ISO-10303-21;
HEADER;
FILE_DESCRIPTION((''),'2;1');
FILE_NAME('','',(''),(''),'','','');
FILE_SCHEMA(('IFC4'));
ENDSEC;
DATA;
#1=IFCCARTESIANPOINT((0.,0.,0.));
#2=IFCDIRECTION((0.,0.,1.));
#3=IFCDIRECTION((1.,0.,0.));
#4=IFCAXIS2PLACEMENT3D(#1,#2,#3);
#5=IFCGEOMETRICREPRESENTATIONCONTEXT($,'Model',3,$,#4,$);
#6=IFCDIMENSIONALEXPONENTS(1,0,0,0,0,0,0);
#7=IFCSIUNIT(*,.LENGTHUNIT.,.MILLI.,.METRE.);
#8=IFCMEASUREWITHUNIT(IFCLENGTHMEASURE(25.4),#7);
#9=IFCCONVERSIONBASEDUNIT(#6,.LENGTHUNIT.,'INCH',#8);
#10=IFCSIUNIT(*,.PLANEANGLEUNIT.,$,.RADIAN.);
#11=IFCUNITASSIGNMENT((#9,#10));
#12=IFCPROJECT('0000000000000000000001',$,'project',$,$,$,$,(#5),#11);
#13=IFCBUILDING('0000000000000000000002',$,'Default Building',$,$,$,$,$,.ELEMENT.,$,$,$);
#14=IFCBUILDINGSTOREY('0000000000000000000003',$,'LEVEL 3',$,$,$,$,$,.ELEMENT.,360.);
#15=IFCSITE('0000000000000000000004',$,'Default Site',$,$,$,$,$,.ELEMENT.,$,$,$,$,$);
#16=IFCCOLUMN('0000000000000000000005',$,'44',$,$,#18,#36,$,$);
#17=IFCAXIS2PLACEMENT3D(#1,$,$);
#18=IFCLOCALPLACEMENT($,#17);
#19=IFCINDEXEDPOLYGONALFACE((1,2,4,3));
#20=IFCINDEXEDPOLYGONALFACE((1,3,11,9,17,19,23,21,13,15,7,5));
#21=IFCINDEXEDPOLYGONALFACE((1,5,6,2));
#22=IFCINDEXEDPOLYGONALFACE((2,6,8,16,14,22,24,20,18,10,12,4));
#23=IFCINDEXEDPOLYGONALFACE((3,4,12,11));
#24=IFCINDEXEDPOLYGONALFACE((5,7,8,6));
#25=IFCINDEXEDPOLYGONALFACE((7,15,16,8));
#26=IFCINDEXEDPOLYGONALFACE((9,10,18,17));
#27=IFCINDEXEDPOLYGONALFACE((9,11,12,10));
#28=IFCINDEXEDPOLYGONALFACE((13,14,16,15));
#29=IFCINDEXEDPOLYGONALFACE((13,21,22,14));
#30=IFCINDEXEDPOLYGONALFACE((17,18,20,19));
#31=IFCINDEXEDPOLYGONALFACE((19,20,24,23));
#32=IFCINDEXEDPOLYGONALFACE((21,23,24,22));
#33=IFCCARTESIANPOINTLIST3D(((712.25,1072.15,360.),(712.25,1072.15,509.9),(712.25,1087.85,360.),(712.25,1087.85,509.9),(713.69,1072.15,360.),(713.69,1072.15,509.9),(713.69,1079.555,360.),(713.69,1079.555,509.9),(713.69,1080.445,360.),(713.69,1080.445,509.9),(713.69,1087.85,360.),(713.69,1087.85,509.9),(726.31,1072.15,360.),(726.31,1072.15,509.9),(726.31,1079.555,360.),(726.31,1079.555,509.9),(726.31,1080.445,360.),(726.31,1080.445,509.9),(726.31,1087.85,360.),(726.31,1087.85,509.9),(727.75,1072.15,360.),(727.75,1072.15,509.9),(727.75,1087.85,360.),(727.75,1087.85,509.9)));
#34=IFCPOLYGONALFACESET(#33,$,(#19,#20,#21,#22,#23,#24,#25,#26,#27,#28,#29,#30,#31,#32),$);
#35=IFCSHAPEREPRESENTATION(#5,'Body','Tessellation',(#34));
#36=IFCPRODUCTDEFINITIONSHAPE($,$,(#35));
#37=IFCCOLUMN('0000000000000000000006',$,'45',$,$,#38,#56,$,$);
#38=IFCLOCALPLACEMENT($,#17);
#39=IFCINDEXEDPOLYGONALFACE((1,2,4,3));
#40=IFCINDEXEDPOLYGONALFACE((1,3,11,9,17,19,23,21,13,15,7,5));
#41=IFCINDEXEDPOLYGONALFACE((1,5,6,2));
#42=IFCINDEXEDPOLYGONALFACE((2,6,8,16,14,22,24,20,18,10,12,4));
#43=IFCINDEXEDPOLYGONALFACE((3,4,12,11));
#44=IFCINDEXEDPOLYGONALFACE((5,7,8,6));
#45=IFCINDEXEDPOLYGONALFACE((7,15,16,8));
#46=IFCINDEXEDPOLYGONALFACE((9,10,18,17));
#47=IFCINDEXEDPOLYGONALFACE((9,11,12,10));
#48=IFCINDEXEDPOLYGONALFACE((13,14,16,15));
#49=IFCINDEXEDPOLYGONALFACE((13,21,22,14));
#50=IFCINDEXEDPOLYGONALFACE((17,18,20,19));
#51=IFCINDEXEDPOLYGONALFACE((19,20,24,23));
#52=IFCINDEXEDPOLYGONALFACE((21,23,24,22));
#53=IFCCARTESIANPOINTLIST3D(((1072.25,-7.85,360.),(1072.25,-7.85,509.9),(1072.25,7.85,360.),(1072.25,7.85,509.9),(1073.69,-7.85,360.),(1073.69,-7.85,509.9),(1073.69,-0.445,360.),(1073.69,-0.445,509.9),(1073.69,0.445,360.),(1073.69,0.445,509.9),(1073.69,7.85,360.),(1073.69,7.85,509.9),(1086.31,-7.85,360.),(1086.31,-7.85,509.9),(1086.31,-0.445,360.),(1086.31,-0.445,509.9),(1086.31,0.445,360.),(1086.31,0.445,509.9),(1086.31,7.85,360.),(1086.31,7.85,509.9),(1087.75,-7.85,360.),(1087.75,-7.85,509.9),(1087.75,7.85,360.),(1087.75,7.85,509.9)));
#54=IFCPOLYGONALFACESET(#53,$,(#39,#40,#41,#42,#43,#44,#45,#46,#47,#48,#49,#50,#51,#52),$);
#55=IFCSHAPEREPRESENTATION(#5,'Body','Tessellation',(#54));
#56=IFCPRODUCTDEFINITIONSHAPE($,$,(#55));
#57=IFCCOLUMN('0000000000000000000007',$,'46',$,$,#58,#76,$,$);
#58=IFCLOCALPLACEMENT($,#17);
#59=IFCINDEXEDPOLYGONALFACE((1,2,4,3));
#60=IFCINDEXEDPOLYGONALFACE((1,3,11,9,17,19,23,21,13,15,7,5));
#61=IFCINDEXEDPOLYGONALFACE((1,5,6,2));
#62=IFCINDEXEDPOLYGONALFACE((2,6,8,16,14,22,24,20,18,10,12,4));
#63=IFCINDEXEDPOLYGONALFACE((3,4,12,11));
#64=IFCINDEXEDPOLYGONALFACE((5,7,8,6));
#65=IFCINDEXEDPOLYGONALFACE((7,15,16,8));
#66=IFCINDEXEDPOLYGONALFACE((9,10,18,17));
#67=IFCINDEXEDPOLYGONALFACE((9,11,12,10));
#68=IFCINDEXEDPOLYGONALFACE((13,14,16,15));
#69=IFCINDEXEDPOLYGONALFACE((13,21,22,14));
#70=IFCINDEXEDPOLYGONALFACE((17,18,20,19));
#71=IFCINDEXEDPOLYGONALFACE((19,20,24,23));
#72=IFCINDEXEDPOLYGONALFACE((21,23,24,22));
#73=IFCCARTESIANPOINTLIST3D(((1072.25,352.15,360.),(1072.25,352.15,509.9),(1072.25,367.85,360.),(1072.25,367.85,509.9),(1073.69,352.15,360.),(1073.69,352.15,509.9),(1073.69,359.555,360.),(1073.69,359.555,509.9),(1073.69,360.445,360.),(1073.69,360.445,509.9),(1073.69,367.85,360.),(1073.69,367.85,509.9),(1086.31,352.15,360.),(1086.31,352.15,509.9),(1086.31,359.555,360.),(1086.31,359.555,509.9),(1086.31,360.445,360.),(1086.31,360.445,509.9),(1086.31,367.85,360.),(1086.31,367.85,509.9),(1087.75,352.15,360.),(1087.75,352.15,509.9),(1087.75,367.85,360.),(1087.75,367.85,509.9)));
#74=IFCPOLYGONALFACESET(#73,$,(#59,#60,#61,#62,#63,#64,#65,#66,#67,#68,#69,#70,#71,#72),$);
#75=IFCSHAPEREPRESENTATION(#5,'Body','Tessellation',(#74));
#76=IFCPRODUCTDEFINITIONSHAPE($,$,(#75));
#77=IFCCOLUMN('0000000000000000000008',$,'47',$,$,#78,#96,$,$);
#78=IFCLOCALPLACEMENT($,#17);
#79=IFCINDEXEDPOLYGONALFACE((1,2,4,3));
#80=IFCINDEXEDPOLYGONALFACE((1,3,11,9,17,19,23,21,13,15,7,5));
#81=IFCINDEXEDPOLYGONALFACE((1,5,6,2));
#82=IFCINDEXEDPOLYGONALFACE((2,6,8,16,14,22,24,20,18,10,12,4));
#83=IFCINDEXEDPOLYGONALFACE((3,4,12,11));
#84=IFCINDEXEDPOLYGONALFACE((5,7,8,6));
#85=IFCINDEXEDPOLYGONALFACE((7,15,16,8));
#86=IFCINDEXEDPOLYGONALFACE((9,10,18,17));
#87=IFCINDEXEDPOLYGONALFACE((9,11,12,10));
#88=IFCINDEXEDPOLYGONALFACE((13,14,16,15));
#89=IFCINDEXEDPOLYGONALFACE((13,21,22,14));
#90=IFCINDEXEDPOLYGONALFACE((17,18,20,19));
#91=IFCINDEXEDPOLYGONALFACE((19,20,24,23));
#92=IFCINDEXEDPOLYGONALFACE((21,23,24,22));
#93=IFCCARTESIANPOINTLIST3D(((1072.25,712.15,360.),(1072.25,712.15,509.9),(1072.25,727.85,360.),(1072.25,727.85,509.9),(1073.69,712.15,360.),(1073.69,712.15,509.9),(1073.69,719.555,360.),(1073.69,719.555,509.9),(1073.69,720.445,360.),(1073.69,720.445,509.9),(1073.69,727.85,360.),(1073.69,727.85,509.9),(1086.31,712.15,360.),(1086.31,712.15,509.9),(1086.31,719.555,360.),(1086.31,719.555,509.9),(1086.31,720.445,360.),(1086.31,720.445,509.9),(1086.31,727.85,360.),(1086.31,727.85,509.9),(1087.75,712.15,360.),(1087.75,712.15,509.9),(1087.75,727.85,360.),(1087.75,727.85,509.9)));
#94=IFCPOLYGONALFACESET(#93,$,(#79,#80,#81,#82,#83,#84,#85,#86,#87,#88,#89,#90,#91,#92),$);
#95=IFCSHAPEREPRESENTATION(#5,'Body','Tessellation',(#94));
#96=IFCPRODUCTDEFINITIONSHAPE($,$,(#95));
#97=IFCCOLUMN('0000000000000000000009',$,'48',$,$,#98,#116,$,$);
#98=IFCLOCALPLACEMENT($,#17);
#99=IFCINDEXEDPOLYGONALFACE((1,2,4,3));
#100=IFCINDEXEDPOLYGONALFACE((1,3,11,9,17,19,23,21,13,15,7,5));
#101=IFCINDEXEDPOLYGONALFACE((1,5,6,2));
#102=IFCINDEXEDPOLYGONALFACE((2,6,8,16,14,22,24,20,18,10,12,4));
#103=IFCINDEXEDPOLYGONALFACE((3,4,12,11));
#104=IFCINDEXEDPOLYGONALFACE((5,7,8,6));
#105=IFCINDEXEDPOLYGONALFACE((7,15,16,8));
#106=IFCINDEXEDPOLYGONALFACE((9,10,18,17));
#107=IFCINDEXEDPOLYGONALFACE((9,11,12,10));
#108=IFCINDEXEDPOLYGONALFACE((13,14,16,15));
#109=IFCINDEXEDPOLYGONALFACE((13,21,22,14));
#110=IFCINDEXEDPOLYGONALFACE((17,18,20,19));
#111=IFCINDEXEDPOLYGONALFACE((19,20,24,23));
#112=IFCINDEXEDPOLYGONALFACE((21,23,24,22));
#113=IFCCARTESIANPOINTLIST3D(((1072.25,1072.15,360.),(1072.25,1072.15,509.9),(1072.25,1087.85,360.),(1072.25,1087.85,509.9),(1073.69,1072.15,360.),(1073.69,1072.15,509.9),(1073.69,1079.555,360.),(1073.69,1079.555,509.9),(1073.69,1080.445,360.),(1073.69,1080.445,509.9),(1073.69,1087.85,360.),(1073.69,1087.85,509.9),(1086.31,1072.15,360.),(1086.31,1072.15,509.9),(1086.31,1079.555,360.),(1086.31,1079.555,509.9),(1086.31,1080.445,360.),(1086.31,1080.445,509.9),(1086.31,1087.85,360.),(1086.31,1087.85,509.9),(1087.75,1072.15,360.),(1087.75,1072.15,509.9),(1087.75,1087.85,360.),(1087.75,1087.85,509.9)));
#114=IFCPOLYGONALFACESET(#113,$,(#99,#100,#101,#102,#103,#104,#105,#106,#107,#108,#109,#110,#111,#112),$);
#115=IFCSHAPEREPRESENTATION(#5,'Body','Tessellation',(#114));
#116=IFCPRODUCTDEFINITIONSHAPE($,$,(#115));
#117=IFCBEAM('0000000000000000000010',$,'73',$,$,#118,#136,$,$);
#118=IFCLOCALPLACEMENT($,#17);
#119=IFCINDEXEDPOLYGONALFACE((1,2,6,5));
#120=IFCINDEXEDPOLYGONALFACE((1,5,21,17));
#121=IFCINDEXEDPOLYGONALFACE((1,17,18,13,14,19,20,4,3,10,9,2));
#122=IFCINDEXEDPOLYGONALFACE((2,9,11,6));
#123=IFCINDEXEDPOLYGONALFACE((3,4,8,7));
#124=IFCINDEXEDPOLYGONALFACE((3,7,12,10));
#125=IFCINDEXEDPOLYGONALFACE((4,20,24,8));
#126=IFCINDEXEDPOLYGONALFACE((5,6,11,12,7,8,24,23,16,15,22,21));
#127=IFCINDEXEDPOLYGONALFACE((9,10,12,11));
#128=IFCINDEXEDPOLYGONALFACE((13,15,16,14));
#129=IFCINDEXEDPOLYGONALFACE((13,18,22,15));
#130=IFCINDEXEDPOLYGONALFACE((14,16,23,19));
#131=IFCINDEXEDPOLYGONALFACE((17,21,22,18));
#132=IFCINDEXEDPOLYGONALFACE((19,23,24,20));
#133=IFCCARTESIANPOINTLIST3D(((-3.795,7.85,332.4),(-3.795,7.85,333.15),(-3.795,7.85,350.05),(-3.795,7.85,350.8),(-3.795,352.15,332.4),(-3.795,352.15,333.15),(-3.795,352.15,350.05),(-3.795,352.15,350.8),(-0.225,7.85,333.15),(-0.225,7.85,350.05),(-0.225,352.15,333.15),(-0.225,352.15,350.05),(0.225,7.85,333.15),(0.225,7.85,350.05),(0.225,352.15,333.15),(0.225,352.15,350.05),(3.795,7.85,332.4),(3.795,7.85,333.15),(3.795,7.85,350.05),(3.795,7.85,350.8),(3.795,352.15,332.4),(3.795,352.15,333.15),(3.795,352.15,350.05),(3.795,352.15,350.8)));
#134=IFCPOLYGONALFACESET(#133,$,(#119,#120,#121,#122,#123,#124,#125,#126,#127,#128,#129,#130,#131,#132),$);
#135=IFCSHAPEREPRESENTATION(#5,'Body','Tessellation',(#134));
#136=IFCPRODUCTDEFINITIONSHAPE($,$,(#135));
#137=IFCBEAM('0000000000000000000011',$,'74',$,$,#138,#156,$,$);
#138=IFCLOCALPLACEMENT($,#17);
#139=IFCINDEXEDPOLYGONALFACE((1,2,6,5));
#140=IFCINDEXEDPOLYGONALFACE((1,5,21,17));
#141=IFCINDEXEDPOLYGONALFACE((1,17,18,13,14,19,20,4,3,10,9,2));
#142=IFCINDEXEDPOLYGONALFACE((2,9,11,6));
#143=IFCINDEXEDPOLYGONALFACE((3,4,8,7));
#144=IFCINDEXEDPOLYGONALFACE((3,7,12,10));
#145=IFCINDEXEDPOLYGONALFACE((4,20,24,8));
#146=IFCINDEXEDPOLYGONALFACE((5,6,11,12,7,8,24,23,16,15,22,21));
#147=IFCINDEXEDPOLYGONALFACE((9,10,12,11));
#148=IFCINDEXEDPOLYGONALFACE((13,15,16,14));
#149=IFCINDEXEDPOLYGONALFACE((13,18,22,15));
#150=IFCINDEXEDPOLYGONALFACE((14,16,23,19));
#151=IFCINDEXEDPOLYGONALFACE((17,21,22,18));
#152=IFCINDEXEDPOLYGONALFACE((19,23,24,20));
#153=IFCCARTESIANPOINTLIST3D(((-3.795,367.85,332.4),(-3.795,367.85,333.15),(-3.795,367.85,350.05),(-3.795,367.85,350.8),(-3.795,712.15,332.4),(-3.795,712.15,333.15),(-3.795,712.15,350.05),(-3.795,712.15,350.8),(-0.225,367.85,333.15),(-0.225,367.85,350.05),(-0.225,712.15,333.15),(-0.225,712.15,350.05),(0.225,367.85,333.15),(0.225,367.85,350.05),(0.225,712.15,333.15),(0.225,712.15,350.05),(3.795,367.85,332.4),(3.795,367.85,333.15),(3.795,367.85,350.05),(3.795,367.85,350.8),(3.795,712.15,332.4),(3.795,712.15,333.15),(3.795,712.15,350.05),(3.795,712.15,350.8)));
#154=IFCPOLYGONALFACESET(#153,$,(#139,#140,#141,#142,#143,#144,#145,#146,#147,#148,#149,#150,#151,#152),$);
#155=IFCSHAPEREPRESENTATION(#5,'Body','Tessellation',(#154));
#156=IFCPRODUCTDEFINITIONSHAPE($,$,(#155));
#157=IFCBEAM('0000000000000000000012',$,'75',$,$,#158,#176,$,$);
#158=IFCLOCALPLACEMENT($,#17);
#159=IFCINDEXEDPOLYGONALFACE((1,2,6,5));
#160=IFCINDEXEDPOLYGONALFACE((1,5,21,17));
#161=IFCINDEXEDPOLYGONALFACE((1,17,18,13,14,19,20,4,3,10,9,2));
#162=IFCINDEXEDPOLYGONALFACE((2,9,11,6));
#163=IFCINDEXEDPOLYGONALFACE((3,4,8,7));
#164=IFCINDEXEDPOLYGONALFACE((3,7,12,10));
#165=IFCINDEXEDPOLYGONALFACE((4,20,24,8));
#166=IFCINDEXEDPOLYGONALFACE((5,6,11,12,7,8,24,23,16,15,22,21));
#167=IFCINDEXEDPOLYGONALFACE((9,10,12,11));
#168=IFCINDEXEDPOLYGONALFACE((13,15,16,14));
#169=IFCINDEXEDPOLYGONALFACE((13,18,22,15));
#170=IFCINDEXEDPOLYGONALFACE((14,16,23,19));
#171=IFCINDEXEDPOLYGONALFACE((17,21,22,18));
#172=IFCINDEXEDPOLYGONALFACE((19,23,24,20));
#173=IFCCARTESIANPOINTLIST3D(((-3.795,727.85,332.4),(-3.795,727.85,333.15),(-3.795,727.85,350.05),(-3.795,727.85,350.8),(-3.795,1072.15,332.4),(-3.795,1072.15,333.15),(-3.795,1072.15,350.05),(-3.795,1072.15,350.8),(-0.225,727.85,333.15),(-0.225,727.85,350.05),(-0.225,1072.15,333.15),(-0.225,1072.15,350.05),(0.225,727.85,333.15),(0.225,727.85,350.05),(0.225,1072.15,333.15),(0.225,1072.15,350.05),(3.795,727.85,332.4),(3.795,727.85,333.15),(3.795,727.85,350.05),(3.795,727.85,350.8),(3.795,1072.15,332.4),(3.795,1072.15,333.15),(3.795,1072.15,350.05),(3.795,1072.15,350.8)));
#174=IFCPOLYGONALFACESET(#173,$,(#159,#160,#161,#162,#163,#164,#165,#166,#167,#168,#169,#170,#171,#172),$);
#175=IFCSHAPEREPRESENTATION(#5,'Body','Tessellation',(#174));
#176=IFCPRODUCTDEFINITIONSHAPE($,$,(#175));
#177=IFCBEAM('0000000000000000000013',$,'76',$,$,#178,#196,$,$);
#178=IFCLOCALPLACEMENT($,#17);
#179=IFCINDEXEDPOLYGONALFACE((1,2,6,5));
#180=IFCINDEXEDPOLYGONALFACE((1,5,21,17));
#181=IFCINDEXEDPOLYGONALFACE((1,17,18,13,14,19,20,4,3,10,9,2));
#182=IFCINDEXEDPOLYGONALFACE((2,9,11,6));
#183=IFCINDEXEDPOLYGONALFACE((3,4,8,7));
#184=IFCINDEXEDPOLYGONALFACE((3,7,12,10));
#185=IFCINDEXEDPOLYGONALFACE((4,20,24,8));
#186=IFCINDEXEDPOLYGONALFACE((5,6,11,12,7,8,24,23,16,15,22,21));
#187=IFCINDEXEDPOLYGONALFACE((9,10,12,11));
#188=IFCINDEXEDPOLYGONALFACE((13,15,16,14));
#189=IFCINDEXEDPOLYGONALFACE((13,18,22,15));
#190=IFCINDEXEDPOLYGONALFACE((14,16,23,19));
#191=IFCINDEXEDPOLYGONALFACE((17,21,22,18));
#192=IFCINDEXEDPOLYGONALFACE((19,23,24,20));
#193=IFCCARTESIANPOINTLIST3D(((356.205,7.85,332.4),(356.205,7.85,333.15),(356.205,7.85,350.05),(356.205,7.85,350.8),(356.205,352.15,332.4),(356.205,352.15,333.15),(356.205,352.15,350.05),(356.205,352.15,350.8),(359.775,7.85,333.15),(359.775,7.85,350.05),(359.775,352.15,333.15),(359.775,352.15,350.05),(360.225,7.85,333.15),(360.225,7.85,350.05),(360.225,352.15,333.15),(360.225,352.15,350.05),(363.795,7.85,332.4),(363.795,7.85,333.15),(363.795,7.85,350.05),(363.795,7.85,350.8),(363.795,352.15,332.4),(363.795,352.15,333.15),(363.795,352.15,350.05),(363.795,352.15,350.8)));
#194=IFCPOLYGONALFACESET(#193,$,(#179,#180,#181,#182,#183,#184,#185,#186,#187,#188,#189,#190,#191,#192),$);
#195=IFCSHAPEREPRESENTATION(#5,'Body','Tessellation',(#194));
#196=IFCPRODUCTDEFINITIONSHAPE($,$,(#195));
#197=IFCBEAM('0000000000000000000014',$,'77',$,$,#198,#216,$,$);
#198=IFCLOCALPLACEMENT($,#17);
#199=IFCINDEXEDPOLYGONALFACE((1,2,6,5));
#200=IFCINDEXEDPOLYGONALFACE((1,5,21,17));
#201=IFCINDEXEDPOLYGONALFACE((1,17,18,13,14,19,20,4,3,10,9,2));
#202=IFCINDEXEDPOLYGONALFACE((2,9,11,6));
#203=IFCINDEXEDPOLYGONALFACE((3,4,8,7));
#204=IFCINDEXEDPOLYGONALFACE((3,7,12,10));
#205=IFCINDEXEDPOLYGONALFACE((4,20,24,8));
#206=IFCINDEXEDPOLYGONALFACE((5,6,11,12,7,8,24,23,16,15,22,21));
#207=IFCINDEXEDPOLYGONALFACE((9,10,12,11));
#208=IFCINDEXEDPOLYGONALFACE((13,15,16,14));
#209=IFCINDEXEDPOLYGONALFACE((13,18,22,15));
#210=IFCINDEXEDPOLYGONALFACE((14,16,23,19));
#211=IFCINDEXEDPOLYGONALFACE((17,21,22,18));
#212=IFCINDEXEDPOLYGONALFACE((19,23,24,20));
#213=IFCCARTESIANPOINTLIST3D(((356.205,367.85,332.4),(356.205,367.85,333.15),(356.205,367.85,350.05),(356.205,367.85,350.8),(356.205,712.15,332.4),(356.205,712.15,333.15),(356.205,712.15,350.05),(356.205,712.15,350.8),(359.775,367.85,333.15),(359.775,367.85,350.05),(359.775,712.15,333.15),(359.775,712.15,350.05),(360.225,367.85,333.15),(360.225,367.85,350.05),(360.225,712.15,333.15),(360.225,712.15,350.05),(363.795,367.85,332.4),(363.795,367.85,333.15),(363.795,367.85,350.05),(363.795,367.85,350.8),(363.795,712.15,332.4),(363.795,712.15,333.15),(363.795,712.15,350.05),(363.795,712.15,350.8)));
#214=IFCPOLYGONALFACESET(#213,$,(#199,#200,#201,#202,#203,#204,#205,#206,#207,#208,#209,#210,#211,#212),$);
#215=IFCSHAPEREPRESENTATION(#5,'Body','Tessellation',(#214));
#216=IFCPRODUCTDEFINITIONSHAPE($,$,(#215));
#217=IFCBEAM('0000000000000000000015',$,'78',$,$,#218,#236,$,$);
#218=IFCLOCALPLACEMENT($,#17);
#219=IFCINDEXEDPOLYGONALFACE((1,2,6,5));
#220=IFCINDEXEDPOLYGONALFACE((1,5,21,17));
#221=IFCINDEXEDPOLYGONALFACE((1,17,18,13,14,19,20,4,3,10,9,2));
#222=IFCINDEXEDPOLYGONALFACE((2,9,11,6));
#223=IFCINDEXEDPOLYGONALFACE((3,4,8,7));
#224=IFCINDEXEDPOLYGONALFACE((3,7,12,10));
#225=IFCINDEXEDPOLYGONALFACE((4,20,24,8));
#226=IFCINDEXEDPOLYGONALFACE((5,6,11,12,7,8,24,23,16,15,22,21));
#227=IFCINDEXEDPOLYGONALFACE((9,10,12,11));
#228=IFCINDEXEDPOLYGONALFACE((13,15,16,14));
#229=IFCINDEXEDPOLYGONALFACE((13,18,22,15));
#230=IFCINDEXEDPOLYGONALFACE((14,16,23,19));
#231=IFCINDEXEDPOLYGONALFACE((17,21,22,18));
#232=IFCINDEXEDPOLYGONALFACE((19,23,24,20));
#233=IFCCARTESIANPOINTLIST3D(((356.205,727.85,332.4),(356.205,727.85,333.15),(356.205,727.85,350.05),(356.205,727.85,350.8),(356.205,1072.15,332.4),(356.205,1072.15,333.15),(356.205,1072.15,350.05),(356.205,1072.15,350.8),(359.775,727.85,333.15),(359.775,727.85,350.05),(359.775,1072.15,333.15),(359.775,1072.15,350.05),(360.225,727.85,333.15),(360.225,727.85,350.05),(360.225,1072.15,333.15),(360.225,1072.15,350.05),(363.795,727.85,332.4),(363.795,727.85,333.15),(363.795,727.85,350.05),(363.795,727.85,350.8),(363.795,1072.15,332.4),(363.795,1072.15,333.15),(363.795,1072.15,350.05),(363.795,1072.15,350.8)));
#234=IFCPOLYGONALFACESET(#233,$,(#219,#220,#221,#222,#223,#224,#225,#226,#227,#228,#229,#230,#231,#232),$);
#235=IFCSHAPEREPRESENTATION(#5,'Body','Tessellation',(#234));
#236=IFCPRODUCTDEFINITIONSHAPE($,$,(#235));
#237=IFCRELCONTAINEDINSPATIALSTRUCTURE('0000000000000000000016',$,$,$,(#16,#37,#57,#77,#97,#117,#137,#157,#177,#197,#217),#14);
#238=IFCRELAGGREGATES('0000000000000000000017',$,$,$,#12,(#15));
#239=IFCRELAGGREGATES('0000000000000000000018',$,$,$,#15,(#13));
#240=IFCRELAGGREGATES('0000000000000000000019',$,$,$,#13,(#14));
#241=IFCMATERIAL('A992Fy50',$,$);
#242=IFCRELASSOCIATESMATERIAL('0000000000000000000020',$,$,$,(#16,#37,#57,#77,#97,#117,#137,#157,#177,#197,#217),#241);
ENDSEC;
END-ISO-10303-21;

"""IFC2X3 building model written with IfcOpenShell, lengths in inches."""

from ifc_helpers import new_model, entity, si_unit, converted_unit, frame, origin_with_axes, origin_2d_with_axis, place, context, project, spatial, i_section, transform_2d, derived_profile, extrude, material, element, save


model = new_model("IFC2X3")

# Units and contexts
model_context = context("Model", 3, world=origin_with_axes())
ifc_project = project(units=[converted_unit("LENGTHUNIT", "INCH", entity("IfcLengthMeasure", 25.4), si_unit("LENGTHUNIT", "METRE", prefix="MILLI"), dimensions=[1, 0, 0, 0, 0, 0, 0]), si_unit("PLANEANGLEUNIT", "RADIAN")], contexts=[model_context])

# Site, building, storey
site = spatial("IfcSite", under=ifc_project, Name="Default Site", CompositionType="ELEMENT")
building = spatial("IfcBuilding", under=site, Name="Default Building", CompositionType="ELEMENT")
storey = spatial("IfcBuildingStorey", under=building, Name="LEVEL 3", CompositionType="ELEMENT", Elevation=360.0)

# Columns
ifc_material = material(Name="A992Fy50")
for number, where, z_axis, x_axis, name in (
    (1, (720.0, 1080.0, 360.0), (0.0, 0.0, 1.0), (0.0, -1.0, 0.0), "44"),
    (2, (1080.0, 0.0, 360.0), (0.0, 0.0, 1.0), (0.0, -1.0, 0.0), "45"),
    (3, (1080.0, 360.0, 360.0), (0.0, 0.0, 1.0), (0.0, -1.0, 0.0), "46"),
    (4, (1080.0, 720.0, 360.0), (0.0, 0.0, 1.0), (0.0, -1.0, 0.0), "47"),
    (5, (1080.0, 1080.0, 360.0), (0.0, 0.0, 1.0), (0.0, -1.0, 0.0), "48"),
):
    element("IfcColumn", number, at=place(None, frame(where, z_axis=z_axis, x_axis=x_axis)), inside=storey, material=ifc_material, Name=name, context=model_context, shape_type="SweptSolid", body=[
        extrude(i_section(OverallWidth=15.7, OverallDepth=15.5, WebThickness=0.89, FlangeThickness=1.44, at=origin_2d_with_axis()), origin_with_axes(), (0.0, 0.0, 1.0), 149.9),
    ])

# Beams
for number, where, z_axis, x_axis, name in (
    (6, (0.0, 7.85, 360.0), (0.0, 1.0, 0.0), (-1.0, 0.0, 0.0), "73"),
    (7, (0.0, 367.85, 360.0), (0.0, 1.0, 0.0), (-1.0, 0.0, 0.0), "74"),
    (8, (0.0, 727.85, 360.0), (0.0, 1.0, 0.0), (-1.0, 0.0, 0.0), "75"),
    (9, (360.0, 7.85, 360.0), (0.0, 1.0, 0.0), (-1.0, 0.0, 0.0), "76"),
    (10, (360.0, 367.85, 360.0), (0.0, 1.0, 0.0), (-1.0, 0.0, 0.0), "77"),
    (11, (360.0, 727.85, 360.0), (0.0, 1.0, 0.0), (-1.0, 0.0, 0.0), "78"),
):
    element("IfcBeam", number, at=place(None, frame(where, z_axis=z_axis, x_axis=x_axis)), inside=storey, material=ifc_material, Name=name, context=model_context, shape_type="SweptSolid", body=[
        extrude(derived_profile(i_section(OverallWidth=7.59, OverallDepth=18.4, WebThickness=0.45, FlangeThickness=0.75, at=origin_2d_with_axis()), transform_2d((0.0, -9.2))), origin_with_axes(), (0.0, 0.0, 1.0), 344.3),
    ])

save(model, "model.ifc")
